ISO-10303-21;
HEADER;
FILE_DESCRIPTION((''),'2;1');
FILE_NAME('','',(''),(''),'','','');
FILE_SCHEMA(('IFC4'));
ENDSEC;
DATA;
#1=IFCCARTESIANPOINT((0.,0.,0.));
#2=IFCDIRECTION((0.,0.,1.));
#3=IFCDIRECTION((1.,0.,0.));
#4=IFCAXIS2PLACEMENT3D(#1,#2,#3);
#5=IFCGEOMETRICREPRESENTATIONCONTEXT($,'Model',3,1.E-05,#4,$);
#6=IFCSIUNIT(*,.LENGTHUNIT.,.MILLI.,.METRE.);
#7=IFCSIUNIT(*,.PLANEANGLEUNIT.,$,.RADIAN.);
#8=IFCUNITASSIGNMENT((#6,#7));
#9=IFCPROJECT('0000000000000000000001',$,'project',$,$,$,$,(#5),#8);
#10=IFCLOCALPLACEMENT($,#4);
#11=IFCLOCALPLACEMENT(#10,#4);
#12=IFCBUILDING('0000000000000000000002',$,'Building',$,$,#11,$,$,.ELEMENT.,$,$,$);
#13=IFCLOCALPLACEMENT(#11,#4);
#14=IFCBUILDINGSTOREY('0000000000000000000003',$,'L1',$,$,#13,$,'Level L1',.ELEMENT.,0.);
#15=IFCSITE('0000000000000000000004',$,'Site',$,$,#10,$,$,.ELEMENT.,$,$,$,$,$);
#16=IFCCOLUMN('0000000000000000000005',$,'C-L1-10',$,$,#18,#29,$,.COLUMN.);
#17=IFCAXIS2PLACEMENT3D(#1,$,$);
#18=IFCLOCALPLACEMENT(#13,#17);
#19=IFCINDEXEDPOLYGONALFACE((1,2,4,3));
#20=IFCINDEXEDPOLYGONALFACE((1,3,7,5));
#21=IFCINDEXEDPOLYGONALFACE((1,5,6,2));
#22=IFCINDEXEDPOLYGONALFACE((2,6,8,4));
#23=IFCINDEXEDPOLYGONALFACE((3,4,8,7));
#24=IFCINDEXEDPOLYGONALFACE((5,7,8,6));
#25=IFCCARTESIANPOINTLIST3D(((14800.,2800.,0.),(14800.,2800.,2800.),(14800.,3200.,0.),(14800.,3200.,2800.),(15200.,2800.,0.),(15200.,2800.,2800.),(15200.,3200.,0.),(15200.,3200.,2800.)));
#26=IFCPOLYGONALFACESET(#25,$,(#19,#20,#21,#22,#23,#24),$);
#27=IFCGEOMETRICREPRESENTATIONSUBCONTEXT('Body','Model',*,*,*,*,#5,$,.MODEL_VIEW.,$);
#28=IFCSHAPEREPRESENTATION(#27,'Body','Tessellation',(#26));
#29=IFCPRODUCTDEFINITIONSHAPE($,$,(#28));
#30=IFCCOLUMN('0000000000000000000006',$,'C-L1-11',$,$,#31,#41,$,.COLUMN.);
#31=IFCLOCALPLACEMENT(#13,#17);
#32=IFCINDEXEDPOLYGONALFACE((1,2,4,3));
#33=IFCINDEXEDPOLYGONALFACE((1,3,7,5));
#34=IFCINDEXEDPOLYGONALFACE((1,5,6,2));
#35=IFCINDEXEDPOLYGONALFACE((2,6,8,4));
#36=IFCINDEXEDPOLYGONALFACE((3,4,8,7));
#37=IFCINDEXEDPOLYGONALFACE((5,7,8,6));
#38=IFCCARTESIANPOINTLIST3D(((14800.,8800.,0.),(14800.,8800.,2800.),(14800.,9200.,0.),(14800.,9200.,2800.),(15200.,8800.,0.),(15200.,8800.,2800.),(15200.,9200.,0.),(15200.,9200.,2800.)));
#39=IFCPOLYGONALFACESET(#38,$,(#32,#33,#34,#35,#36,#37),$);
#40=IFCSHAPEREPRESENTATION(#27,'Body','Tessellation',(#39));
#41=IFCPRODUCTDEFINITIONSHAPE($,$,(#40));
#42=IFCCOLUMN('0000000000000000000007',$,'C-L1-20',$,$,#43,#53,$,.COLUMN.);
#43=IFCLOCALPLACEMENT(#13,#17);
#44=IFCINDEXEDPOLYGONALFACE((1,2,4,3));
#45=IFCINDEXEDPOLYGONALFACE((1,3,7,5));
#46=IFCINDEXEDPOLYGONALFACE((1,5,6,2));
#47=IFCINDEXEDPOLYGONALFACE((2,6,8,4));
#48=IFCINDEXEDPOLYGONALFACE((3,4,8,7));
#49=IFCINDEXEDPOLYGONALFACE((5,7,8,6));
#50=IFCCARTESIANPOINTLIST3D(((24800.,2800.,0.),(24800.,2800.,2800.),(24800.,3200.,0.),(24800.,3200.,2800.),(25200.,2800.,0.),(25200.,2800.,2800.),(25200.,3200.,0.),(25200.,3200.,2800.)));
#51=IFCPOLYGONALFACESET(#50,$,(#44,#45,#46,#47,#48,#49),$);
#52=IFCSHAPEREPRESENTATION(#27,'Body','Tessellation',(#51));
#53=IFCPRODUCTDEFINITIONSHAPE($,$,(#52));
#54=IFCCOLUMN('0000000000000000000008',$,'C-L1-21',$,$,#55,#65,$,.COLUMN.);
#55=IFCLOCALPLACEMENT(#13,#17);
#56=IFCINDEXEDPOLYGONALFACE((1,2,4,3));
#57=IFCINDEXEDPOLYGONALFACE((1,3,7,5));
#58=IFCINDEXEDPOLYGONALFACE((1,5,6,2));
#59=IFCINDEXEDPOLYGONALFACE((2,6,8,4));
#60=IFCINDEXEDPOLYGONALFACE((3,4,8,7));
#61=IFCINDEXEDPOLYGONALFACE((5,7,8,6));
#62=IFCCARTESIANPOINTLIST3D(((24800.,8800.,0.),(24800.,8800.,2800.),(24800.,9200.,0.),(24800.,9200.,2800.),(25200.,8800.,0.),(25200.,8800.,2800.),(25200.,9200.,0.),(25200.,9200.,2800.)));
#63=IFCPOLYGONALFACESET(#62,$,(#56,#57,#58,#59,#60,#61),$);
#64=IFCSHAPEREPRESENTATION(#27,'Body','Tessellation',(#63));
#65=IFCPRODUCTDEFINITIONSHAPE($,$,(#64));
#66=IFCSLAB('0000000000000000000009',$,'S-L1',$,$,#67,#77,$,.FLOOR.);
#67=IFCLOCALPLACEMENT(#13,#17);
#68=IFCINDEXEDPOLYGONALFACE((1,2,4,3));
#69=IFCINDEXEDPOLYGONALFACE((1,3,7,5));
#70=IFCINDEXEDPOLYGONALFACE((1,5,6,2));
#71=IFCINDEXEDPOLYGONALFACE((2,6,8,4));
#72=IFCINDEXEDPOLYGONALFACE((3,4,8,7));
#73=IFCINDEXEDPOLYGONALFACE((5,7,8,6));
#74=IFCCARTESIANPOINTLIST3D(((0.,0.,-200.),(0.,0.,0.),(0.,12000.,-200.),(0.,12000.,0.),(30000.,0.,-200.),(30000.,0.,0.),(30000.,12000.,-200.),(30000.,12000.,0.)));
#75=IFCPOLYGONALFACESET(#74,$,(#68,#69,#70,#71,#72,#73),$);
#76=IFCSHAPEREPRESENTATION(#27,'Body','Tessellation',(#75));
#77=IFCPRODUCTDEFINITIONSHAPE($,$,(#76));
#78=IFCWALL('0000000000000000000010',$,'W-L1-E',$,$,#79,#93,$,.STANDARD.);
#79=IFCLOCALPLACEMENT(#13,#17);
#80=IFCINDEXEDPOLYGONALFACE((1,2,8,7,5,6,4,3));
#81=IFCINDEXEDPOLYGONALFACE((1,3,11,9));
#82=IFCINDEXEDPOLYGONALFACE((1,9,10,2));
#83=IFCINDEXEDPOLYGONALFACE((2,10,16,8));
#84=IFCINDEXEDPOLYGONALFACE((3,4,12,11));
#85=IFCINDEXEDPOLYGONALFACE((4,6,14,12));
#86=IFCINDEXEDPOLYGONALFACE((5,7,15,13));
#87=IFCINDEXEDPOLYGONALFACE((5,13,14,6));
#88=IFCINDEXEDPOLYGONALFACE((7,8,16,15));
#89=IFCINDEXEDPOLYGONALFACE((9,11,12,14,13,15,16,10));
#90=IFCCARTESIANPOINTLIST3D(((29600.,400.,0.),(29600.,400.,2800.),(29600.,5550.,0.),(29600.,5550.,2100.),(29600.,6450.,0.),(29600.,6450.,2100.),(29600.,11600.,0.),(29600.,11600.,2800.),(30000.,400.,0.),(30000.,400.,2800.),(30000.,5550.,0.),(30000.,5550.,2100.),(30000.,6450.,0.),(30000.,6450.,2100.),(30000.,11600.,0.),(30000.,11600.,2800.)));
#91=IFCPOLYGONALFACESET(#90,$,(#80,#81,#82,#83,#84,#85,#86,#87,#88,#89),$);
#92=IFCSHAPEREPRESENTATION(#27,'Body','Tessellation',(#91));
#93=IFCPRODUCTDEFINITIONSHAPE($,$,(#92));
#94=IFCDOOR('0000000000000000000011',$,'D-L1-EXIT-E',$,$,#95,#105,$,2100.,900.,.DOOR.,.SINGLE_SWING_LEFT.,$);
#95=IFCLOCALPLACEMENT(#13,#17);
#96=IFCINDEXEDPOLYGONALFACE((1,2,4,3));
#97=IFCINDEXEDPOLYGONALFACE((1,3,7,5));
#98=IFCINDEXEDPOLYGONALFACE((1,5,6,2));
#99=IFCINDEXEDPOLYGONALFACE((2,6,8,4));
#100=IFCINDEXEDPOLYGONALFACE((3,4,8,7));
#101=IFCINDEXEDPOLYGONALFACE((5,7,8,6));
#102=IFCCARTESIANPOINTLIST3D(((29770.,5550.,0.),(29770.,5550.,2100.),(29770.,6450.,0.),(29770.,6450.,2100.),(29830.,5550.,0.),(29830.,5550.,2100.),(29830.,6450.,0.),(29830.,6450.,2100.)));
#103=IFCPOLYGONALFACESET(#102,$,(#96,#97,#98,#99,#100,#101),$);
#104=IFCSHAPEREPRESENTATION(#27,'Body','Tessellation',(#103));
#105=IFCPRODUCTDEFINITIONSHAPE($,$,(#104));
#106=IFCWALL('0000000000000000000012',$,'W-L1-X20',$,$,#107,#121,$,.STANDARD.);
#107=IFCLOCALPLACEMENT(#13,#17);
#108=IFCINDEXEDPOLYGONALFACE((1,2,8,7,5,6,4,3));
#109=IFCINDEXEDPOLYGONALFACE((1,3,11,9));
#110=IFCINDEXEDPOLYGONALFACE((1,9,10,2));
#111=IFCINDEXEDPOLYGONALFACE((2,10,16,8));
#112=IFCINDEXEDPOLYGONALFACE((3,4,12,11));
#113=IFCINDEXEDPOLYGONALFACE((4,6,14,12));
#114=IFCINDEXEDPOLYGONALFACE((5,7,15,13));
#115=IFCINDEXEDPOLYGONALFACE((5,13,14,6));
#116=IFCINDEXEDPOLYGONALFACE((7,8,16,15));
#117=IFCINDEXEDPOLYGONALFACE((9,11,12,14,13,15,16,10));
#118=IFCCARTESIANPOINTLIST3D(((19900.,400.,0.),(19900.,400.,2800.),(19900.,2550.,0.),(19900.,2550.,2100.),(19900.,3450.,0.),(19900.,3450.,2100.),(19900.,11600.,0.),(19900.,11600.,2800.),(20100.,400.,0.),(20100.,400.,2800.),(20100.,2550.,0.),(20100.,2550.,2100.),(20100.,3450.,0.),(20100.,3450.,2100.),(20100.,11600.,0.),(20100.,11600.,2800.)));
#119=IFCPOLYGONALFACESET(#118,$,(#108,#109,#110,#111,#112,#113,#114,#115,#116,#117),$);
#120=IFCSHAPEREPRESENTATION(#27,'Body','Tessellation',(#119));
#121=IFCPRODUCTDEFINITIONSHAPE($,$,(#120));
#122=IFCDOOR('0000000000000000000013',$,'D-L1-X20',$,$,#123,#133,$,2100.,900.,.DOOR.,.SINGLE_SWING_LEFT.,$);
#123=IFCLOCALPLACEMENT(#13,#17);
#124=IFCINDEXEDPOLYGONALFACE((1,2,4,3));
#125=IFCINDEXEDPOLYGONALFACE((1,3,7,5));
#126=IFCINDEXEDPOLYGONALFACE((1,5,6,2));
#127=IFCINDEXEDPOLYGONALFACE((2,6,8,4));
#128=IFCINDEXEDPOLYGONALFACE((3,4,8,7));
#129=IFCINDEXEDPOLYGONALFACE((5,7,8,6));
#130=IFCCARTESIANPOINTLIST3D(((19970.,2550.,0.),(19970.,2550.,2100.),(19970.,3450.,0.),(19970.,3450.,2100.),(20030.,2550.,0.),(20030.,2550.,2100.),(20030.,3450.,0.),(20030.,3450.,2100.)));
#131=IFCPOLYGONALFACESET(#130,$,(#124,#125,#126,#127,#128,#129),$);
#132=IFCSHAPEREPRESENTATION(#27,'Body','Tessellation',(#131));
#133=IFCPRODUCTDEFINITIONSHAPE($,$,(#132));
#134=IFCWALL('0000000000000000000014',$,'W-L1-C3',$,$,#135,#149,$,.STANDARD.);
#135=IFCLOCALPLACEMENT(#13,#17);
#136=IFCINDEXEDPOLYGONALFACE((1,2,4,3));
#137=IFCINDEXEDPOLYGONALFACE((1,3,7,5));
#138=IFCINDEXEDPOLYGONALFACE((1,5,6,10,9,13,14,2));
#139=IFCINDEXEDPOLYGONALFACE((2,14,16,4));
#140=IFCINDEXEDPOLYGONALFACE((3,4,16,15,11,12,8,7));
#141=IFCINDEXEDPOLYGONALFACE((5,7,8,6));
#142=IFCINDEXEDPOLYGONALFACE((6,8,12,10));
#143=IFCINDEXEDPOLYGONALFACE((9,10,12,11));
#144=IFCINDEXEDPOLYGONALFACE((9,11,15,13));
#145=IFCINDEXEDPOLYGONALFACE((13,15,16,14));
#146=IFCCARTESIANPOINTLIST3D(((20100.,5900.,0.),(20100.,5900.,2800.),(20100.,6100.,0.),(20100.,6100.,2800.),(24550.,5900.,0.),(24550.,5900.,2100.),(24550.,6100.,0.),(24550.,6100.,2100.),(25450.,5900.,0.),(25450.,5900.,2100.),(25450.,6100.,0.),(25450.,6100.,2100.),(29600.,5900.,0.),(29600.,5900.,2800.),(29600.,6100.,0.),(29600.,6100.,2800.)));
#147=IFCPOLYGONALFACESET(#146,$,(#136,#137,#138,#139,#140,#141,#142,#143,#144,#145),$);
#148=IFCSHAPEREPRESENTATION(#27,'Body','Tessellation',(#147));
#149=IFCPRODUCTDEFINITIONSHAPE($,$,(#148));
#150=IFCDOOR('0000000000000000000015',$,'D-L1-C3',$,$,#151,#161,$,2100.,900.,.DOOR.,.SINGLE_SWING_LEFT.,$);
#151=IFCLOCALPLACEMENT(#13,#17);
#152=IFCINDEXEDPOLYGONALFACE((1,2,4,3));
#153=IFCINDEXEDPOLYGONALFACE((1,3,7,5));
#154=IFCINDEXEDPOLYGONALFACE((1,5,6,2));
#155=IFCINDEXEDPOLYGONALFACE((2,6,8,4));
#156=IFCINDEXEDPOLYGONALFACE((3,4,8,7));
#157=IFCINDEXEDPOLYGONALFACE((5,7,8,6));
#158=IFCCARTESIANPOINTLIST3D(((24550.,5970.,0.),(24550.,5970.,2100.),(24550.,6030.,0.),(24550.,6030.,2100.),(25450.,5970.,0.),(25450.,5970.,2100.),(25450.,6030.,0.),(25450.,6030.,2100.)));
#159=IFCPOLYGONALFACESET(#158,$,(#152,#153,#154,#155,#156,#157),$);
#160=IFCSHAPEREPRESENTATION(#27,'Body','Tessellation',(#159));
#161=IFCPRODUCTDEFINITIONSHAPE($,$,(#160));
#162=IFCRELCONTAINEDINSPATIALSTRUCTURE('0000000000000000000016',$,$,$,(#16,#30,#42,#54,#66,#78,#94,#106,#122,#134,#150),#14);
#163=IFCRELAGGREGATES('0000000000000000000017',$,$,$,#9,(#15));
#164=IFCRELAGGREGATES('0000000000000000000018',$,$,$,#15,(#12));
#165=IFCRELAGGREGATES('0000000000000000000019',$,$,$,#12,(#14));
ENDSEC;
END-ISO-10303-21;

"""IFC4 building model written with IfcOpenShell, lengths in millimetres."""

from ifc_helpers import new_model, si_unit, frame, origin_with_axes, origin_2d, place, context, subcontext, project, spatial, rectangle, extrude, element, fill, save


model = new_model("IFC4")

# Units and contexts
model_context = context("Model", 3, precision=1e-05, world=origin_with_axes())
body_context = subcontext(model_context, "Body", "Model", "MODEL_VIEW")
ifc_project = project(units=[si_unit("LENGTHUNIT", "METRE", prefix="MILLI"), si_unit("PLANEANGLEUNIT", "RADIAN")], contexts=[model_context])

# Site, building, storey
site_placement = place(None, origin_with_axes())
site = spatial("IfcSite", under=ifc_project, at=site_placement, Name="Site", CompositionType="ELEMENT")
building_placement = place(site_placement, origin_with_axes())
building = spatial("IfcBuilding", under=site, at=building_placement, Name="Building", CompositionType="ELEMENT")
storey_placement = place(building_placement, origin_with_axes())
storey = spatial("IfcBuildingStorey", under=building, at=storey_placement, Name="L1", LongName="Level L1", CompositionType="ELEMENT", Elevation=0.0)

# Columns
for number, where, z_axis, x_axis, name in (
    (1, (15000.0, 3000.0, 0.0), (0.0, 0.0, 1.0), (1.0, 0.0, 0.0), "C-L1-10"),
    (2, (15000.0, 9000.0, 0.0), (0.0, 0.0, 1.0), (1.0, 0.0, 0.0), "C-L1-11"),
    (3, (25000.0, 3000.0, 0.0), (0.0, 0.0, 1.0), (1.0, 0.0, 0.0), "C-L1-20"),
    (4, (25000.0, 9000.0, 0.0), (0.0, 0.0, 1.0), (1.0, 0.0, 0.0), "C-L1-21"),
):
    element("IfcColumn", number, at=place(storey_placement, frame(where, z_axis=z_axis, x_axis=x_axis)), inside=storey, Name=name, PredefinedType="COLUMN", context=body_context, shape_type="SweptSolid", body=[
        extrude(rectangle(XDim=400.0, YDim=400.0, at=origin_2d()), origin_with_axes(), (0.0, 0.0, 1.0), 2800.0),
    ])

# Slab
slab_placement = place(storey_placement, frame((15000.0, 6000.0, -200.0), z_axis=(0.0, 0.0, 1.0), x_axis=(1.0, 0.0, 0.0)))
element("IfcSlab", 5, at=slab_placement, inside=storey, Name="S-L1", PredefinedType="FLOOR", context=body_context, shape_type="SweptSolid", body=[
    extrude(rectangle(XDim=30000.0, YDim=12000.0, at=origin_2d()), origin_with_axes(), (0.0, 0.0, 1.0), 200.0),
])

# Walls, openings, doors
wall_1_placement = place(storey_placement, frame((29800.0, 6000.0, 0.0), z_axis=(0.0, 0.0, 1.0), x_axis=(1.0, 0.0, 0.0)))
wall_1 = element("IfcWall", 6, at=wall_1_placement, inside=storey, Name="W-L1-E", PredefinedType="STANDARD", context=body_context, shape_type="SweptSolid", body=[
    extrude(rectangle(XDim=400.0, YDim=11200.0, at=origin_2d()), origin_with_axes(), (0.0, 0.0, 1.0), 2800.0),
])
opening_1_placement = place(wall_1_placement, origin_with_axes())
opening_1 = element("IfcOpeningElement", 7, at=opening_1_placement, cuts=wall_1, PredefinedType="OPENING", context=body_context, shape_type="SweptSolid", body=[
    extrude(rectangle(XDim=500.0, YDim=900.0, at=origin_2d()), origin_with_axes(), (0.0, 0.0, 1.0), 2100.0),
])
door_1_placement = place(wall_1_placement, origin_with_axes())
door_1 = element("IfcDoor", 8, at=door_1_placement, inside=storey, Name="D-L1-EXIT-E", OperationType="SINGLE_SWING_LEFT", OverallHeight=2100.0, OverallWidth=900.0, PredefinedType="DOOR", context=body_context, shape_type="SweptSolid", body=[
    extrude(rectangle(XDim=60.0, YDim=900.0, at=origin_2d()), origin_with_axes(), (0.0, 0.0, 1.0), 2100.0),
])
fill(opening_1, door_1)
wall_2_placement = place(storey_placement, frame((20000.0, 6000.0, 0.0), z_axis=(0.0, 0.0, 1.0), x_axis=(1.0, 0.0, 0.0)))
wall_2 = element("IfcWall", 9, at=wall_2_placement, inside=storey, Name="W-L1-X20", PredefinedType="STANDARD", context=body_context, shape_type="SweptSolid", body=[
    extrude(rectangle(XDim=200.0, YDim=11200.0, at=origin_2d()), origin_with_axes(), (0.0, 0.0, 1.0), 2800.0),
])
opening_2_placement = place(wall_2_placement, frame((0.0, -3000.0, 0.0), z_axis=(0.0, 0.0, 1.0), x_axis=(1.0, 0.0, 0.0)))
opening_2 = element("IfcOpeningElement", 10, at=opening_2_placement, cuts=wall_2, PredefinedType="OPENING", context=body_context, shape_type="SweptSolid", body=[
    extrude(rectangle(XDim=300.0, YDim=900.0, at=origin_2d()), origin_with_axes(), (0.0, 0.0, 1.0), 2100.0),
])
door_2_placement = place(wall_2_placement, frame((0.0, -3000.0, 0.0), z_axis=(0.0, 0.0, 1.0), x_axis=(1.0, 0.0, 0.0)))
door_2 = element("IfcDoor", 11, at=door_2_placement, inside=storey, Name="D-L1-X20", OperationType="SINGLE_SWING_LEFT", OverallHeight=2100.0, OverallWidth=900.0, PredefinedType="DOOR", context=body_context, shape_type="SweptSolid", body=[
    extrude(rectangle(XDim=60.0, YDim=900.0, at=origin_2d()), origin_with_axes(), (0.0, 0.0, 1.0), 2100.0),
])
fill(opening_2, door_2)
wall_3_placement = place(storey_placement, frame((24850.0, 6000.0, 0.0), z_axis=(0.0, 0.0, 1.0), x_axis=(1.0, 0.0, 0.0)))
wall_3 = element("IfcWall", 12, at=wall_3_placement, inside=storey, Name="W-L1-C3", PredefinedType="STANDARD", context=body_context, shape_type="SweptSolid", body=[
    extrude(rectangle(XDim=9500.0, YDim=200.0, at=origin_2d()), origin_with_axes(), (0.0, 0.0, 1.0), 2800.0),
])
opening_3_placement = place(wall_3_placement, frame((150.0, 0.0, 0.0), z_axis=(0.0, 0.0, 1.0), x_axis=(1.0, 0.0, 0.0)))
opening_3 = element("IfcOpeningElement", 13, at=opening_3_placement, cuts=wall_3, PredefinedType="OPENING", context=body_context, shape_type="SweptSolid", body=[
    extrude(rectangle(XDim=900.0, YDim=300.0, at=origin_2d()), origin_with_axes(), (0.0, 0.0, 1.0), 2100.0),
])
door_3_placement = place(wall_3_placement, frame((150.0, 0.0, 0.0), z_axis=(0.0, 0.0, 1.0), x_axis=(1.0, 0.0, 0.0)))
door_3 = element("IfcDoor", 14, at=door_3_placement, inside=storey, Name="D-L1-C3", OperationType="SINGLE_SWING_LEFT", OverallHeight=2100.0, OverallWidth=900.0, PredefinedType="DOOR", context=body_context, shape_type="SweptSolid", body=[
    extrude(rectangle(XDim=900.0, YDim=60.0, at=origin_2d()), origin_with_axes(), (0.0, 0.0, 1.0), 2100.0),
])
fill(opening_3, door_3)

save(model, "model.ifc")
